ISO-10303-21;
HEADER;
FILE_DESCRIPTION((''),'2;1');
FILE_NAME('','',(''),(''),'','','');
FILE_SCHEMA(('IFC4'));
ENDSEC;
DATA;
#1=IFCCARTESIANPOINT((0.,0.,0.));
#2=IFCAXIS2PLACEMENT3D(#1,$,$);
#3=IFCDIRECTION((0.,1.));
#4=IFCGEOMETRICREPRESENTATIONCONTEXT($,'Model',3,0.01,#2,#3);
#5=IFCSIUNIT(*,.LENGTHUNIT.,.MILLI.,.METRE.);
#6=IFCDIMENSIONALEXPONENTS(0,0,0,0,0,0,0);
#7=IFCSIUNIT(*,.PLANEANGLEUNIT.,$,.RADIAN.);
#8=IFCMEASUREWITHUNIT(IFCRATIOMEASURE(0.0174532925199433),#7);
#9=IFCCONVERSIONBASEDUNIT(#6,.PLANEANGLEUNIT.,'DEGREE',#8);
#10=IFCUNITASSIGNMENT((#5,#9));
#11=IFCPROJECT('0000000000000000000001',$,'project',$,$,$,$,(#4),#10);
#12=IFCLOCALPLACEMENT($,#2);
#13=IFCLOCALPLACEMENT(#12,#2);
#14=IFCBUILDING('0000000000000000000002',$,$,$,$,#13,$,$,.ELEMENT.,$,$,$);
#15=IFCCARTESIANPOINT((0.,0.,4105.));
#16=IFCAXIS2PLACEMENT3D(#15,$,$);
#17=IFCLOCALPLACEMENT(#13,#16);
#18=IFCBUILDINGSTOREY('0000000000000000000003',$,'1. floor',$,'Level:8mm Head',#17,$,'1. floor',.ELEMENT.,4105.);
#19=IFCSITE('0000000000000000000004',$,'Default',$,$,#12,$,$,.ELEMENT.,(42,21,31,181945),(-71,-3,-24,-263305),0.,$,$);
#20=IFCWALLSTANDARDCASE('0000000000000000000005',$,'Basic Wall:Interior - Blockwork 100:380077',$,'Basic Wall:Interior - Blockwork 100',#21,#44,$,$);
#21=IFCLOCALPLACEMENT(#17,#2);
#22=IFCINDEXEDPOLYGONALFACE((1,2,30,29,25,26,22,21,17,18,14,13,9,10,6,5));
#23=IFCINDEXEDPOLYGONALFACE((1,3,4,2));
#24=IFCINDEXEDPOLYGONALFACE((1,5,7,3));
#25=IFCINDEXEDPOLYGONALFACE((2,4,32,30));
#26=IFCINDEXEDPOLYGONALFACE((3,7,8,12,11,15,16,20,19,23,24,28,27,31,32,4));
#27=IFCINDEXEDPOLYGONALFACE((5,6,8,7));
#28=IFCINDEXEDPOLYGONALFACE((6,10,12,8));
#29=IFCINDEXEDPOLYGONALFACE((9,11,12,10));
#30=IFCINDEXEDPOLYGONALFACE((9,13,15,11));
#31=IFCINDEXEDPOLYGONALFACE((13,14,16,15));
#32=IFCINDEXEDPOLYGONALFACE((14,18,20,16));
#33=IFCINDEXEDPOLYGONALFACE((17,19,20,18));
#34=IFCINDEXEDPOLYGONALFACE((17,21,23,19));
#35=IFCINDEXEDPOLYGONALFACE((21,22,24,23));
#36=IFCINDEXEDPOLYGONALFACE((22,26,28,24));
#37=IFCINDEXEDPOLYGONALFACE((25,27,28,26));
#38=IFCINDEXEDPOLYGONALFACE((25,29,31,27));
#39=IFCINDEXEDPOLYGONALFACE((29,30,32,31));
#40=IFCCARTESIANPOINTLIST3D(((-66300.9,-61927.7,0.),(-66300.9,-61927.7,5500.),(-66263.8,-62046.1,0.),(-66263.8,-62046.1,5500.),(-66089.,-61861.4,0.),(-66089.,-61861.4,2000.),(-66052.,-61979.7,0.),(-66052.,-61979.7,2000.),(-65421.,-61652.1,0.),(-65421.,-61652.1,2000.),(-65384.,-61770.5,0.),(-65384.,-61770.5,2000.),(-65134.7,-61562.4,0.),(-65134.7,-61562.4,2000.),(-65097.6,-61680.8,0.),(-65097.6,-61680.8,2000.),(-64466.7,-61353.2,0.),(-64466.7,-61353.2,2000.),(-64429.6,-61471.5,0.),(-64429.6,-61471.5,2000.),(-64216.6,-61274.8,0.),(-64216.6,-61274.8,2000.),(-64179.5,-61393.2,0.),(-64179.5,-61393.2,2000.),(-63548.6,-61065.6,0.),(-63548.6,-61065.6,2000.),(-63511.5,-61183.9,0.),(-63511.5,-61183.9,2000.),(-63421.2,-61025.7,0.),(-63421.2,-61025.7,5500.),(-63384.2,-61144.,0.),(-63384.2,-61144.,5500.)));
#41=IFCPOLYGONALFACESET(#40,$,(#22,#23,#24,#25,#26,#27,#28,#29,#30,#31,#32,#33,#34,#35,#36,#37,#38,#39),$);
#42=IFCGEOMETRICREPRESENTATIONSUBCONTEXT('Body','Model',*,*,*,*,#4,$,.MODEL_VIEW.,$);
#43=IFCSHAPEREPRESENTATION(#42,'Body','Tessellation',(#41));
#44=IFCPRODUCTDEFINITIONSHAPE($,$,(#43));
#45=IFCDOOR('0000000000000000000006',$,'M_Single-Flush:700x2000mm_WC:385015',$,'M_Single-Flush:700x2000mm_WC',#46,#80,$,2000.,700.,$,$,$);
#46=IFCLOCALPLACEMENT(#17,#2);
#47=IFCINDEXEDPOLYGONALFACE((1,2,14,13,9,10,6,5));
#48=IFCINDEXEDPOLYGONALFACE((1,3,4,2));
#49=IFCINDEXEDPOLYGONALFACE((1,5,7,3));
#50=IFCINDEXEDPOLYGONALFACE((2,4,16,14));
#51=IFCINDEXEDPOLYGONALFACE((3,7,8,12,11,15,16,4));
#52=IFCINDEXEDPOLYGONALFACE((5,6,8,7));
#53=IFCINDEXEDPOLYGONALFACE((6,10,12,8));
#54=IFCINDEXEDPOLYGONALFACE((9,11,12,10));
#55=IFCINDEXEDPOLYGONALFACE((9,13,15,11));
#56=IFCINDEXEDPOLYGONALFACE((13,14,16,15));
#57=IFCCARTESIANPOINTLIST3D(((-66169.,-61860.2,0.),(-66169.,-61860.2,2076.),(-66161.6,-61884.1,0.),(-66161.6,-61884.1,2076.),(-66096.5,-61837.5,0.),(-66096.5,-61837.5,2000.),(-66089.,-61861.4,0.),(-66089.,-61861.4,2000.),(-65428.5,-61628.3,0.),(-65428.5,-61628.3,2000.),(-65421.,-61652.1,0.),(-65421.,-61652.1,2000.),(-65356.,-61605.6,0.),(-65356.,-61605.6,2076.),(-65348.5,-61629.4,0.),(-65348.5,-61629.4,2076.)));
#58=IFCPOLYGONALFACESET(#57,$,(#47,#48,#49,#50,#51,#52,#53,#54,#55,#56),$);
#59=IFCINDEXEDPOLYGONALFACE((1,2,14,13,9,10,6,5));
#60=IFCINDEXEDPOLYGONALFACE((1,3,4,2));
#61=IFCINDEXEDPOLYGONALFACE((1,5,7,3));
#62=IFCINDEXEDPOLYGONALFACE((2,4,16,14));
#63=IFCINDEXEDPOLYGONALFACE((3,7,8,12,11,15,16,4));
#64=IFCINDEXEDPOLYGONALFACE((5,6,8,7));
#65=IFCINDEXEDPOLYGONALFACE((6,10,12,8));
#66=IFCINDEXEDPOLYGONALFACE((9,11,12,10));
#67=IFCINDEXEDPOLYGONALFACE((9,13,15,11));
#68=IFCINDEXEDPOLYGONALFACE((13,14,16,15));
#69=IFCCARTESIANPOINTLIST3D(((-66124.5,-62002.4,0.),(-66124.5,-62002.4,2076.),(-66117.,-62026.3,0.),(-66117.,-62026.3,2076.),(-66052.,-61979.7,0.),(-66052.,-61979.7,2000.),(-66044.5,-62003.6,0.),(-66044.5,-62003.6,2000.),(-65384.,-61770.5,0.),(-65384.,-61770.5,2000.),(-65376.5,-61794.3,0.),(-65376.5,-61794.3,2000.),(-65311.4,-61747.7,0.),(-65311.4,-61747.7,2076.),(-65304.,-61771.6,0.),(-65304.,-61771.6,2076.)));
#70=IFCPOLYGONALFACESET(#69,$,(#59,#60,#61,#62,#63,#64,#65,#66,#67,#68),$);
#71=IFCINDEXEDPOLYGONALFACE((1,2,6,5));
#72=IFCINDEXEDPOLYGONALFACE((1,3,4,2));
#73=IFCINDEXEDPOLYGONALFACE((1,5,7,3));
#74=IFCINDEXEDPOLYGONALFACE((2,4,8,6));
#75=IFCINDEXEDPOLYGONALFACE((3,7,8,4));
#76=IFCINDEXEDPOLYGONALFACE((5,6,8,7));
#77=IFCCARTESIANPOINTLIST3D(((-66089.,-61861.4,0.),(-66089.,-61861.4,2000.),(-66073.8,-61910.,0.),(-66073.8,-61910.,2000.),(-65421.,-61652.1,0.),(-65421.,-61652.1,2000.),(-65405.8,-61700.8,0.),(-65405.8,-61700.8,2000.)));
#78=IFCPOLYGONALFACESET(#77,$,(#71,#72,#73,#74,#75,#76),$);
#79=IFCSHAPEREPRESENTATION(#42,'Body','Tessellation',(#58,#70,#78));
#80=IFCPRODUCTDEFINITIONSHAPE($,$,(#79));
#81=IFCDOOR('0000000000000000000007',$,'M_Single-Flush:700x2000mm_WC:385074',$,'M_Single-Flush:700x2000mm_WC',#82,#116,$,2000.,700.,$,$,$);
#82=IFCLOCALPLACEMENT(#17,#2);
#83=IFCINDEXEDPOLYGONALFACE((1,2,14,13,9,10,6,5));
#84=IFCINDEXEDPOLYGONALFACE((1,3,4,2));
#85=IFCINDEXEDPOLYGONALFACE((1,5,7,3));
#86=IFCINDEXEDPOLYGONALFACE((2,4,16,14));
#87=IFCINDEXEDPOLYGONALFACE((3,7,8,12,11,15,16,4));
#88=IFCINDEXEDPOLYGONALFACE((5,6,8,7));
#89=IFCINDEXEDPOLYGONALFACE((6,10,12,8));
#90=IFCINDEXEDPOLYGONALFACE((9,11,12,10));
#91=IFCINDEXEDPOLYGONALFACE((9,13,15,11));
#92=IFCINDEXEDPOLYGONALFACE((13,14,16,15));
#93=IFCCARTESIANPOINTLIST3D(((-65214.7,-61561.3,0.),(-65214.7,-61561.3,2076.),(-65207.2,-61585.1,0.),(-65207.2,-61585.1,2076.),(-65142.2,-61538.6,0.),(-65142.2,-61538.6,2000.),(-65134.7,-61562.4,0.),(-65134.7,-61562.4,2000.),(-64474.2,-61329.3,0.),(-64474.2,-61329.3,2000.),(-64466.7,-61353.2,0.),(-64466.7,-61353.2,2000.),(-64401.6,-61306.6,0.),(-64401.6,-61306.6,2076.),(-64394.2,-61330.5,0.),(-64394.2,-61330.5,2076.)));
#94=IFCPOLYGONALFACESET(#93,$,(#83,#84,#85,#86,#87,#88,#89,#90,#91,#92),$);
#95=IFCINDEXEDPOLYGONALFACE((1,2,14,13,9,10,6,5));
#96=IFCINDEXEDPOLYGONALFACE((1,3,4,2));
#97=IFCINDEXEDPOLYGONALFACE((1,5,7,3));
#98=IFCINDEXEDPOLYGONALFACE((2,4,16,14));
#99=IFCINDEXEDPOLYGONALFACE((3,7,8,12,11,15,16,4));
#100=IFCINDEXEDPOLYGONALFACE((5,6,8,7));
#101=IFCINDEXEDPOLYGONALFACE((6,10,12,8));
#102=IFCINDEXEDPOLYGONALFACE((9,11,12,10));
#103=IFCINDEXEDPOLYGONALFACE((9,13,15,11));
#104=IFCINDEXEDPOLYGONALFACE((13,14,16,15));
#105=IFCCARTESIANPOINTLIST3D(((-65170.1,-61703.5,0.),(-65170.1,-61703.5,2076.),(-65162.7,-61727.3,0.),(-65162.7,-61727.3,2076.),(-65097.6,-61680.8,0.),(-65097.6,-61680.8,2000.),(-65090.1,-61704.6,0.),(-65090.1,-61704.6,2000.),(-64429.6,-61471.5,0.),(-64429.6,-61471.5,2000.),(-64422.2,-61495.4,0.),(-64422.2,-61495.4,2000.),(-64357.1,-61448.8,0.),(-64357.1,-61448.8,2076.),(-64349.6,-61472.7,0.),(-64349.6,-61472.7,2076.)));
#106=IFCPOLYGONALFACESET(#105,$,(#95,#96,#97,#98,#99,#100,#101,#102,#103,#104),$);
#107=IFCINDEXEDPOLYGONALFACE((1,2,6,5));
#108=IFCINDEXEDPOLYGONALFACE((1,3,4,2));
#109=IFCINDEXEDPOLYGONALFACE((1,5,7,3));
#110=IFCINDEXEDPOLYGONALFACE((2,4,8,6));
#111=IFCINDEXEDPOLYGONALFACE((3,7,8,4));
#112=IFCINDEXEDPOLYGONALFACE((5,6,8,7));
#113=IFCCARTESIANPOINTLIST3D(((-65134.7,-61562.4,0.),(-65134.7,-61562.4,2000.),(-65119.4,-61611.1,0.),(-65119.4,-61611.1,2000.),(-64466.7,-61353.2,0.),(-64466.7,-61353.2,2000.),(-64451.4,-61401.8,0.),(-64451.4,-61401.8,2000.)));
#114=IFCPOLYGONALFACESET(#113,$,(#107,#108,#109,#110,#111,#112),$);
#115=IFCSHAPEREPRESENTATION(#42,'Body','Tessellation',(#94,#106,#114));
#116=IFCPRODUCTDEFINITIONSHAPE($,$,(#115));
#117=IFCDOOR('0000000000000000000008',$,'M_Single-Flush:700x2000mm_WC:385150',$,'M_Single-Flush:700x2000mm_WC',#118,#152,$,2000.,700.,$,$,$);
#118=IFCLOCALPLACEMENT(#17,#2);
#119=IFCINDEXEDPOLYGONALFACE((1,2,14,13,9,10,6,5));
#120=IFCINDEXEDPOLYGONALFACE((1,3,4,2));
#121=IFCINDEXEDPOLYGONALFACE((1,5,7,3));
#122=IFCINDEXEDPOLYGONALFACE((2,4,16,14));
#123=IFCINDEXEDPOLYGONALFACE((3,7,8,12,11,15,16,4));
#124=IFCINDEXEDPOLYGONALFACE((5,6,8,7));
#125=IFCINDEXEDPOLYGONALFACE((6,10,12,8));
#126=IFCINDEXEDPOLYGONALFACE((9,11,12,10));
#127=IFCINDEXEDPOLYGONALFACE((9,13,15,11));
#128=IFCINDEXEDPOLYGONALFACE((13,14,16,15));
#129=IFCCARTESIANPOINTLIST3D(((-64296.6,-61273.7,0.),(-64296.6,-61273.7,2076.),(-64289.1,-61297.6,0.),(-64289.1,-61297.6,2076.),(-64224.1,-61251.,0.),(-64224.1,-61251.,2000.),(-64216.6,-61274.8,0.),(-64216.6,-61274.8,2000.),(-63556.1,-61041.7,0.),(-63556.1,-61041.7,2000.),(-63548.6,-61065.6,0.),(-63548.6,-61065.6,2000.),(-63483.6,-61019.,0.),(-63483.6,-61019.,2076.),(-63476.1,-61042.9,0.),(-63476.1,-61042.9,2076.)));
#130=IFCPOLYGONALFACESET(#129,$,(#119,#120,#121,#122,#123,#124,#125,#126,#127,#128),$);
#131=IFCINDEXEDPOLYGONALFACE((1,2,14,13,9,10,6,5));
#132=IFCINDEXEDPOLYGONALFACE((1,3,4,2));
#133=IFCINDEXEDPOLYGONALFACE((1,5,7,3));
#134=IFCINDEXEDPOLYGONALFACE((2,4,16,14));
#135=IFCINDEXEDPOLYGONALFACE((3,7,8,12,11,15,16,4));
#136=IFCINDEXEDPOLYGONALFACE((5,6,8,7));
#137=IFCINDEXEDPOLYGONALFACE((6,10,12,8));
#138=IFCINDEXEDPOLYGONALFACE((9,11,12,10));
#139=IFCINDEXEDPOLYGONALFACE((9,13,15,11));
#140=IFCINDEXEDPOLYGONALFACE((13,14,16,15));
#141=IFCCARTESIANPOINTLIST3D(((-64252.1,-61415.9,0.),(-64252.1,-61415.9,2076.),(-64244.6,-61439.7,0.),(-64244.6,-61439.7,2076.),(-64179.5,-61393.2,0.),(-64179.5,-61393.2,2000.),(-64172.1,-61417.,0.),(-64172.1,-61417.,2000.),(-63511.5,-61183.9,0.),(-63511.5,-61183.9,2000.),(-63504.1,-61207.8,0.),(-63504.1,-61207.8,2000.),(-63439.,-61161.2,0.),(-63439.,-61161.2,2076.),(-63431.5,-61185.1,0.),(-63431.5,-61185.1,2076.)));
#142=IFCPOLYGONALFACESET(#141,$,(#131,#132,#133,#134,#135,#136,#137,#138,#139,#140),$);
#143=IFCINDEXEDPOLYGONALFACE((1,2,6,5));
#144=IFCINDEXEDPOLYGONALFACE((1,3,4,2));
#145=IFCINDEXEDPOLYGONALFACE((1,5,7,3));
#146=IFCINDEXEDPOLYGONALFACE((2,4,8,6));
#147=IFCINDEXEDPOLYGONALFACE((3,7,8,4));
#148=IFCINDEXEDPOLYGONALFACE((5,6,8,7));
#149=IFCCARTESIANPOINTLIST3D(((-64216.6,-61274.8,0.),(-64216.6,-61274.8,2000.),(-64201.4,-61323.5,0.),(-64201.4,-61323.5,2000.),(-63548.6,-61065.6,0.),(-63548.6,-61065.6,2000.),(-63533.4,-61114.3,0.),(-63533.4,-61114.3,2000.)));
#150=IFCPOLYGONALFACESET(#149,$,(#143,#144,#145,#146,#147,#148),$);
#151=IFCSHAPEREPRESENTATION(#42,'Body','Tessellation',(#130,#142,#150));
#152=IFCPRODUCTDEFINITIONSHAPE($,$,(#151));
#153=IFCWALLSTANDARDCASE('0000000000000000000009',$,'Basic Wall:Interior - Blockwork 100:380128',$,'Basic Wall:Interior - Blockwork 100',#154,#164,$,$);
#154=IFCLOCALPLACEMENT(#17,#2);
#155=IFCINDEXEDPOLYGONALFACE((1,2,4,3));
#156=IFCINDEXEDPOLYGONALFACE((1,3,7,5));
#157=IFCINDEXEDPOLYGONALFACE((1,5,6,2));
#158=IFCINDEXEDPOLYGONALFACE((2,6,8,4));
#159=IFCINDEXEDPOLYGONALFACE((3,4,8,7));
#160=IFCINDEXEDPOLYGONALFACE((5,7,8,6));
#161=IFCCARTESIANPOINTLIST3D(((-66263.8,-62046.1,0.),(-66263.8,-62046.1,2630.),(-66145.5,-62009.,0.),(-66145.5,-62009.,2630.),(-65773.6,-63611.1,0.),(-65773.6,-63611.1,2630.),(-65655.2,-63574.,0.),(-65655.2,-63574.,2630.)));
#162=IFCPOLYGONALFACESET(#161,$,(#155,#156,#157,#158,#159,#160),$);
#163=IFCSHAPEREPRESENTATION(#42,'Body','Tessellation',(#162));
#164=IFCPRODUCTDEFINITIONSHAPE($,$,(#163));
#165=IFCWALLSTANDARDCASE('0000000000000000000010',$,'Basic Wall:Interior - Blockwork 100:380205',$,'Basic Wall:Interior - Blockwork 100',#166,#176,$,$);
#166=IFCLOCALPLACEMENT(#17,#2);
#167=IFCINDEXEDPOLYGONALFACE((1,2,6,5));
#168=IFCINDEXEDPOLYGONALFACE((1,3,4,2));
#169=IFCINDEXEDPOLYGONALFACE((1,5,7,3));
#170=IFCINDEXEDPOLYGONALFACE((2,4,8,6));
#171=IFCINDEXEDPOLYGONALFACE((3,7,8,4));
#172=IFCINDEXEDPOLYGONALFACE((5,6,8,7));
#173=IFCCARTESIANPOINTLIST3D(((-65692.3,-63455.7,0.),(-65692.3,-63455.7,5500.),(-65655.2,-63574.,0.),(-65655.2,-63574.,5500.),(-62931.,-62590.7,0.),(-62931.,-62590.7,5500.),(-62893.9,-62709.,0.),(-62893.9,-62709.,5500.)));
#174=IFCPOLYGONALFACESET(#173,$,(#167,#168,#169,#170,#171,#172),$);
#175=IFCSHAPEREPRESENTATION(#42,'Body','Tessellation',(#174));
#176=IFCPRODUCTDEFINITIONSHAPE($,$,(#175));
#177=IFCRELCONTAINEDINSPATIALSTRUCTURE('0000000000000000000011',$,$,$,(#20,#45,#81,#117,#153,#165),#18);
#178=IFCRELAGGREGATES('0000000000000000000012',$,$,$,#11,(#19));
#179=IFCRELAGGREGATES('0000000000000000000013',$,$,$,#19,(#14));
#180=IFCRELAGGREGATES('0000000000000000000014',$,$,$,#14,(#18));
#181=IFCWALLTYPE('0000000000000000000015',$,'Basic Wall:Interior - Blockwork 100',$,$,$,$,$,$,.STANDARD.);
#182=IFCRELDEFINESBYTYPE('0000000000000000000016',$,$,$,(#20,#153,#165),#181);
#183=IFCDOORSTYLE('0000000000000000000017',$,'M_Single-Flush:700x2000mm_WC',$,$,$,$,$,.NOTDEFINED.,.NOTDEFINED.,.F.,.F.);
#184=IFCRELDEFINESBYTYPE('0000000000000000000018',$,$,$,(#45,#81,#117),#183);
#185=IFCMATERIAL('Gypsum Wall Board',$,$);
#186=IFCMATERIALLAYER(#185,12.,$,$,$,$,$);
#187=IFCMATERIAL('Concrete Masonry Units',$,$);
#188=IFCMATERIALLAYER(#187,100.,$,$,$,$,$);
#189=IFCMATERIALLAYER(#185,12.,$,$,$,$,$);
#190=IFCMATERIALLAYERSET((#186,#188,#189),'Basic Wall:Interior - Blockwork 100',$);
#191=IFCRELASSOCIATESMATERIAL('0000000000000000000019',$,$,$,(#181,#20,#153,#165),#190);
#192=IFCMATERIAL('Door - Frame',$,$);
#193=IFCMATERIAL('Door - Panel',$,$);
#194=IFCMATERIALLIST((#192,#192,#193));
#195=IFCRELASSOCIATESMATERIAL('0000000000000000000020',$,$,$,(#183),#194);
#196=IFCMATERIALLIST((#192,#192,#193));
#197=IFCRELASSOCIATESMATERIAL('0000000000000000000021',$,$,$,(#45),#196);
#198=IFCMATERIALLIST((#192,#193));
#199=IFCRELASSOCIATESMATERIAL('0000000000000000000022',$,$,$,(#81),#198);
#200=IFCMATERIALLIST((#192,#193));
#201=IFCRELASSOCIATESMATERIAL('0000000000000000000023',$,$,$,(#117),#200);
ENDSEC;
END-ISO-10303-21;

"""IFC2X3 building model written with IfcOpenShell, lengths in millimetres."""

from ifc_helpers import new_model, entity, si_unit, converted_unit, direction, frame, frame_2d, origin, origin_2d_with_axis, place, context, subcontext, project, spatial, polyline, rectangle, outline, extrude, source, transform, mapped, material, material_list, layer, layer_set, layer_usage, type_object, type_shapes, element, fill, save


model = new_model("IFC2X3")

# Units and contexts
model_context = context("Model", 3, precision=0.01, world=origin(), true_north=direction((0.0, 1.0)))
body_context = subcontext(model_context, "Body", "Model", "MODEL_VIEW")
ifc_project = project(units=[si_unit("LENGTHUNIT", "METRE", prefix="MILLI"), converted_unit("PLANEANGLEUNIT", "DEGREE", entity("IfcRatioMeasure", 0.0174532925199433), si_unit("PLANEANGLEUNIT", "RADIAN"), dimensions=[0, 0, 0, 0, 0, 0, 0])], contexts=[model_context])

# Site, building, storey
site_placement = place(None, origin())
site = spatial("IfcSite", under=ifc_project, at=site_placement, Name="Default", CompositionType="ELEMENT", RefLatitude=(42, 21, 31, 181945), RefLongitude=(-71, -3, -24, -263305), RefElevation=0.0)
building_placement = place(site_placement, origin())
building = spatial("IfcBuilding", under=site, at=building_placement, CompositionType="ELEMENT")
storey_placement = place(building_placement, frame((0.0, 0.0, 4105.0)))
storey = spatial("IfcBuildingStorey", under=building, at=storey_placement, Name="1. floor", ObjectType="Level:8mm Head", LongName="1. floor", CompositionType="ELEMENT", Elevation=4105.0)

# Shared definitions
ifc_material_1 = material(Name="Gypsum Wall Board")
ifc_layer_1 = layer(ifc_material_1, 12.0)
ifc_material_2 = material(Name="Concrete Masonry Units")
ifc_layer_2 = layer(ifc_material_2, 100.0)
ifc_layer_3 = layer(ifc_material_1, 12.0)
ifc_layer_set_1 = layer_set([ifc_layer_1, ifc_layer_2, ifc_layer_3], Name="Basic Wall:Interior - Blockwork 100")
wall_type_1 = type_object("IfcWallType", Name="Basic Wall:Interior - Blockwork 100", PredefinedType="STANDARD", material=ifc_layer_set_1)
ifc_material_3 = material(Name="Door - Frame")
ifc_material_4 = material(Name="Door - Panel")

# Wall, openings, doors
ifc_layer_usage_1 = layer_usage(ifc_layer_set_1, "AXIS2", "NEGATIVE", 62.0)
wall_1_placement = place(storey_placement, frame((-63402.7, -61084.9, 0.0), z_axis=(0.0, 0.0, 1.0), x_axis=(-0.954277, -0.298924, 0.0)))
wall_1 = element("IfcWallStandardCase", 1, at=wall_1_placement, inside=storey, type_object=wall_type_1, material=ifc_layer_usage_1, Name="Basic Wall:Interior - Blockwork 100:380077", ObjectType="Basic Wall:Interior - Blockwork 100", context=body_context, shape_type="SweptSolid", body=[
    extrude(rectangle(XDim=3017.6, YDim=124.0, at=frame_2d((1508.8, 0.0), x_axis=(-1.0, 0.0))), origin(), (0.0, 0.0, 1.0), 5500.0),
])
opening_1_placement = place(wall_1_placement, frame((2795.6, 62.0, 0.0)))
opening_1 = element("IfcOpeningElement", 2, at=opening_1_placement, cuts=wall_1, ObjectType="Opening", context=body_context, shape_type="SweptSolid", body=[
    extrude(rectangle(XDim=700.0, YDim=2000.0, at=frame_2d((1000.0, 350.0), x_axis=(0.0, 1.0))), frame((0.0, 0.0, 0.0), z_axis=(0.0, -1.0, 0.0), x_axis=(0.0, 0.0, 1.0)), (0.0, 0.0, 1.0), 124.0),
])
opening_2_placement = place(wall_1_placement, frame((1795.5, 62.0, 0.0)))
opening_2 = element("IfcOpeningElement", 3, at=opening_2_placement, cuts=wall_1, ObjectType="Opening", context=body_context, shape_type="SweptSolid", body=[
    extrude(rectangle(XDim=700.0, YDim=2000.0, at=frame_2d((1000.0, 350.0), x_axis=(0.0, 1.0))), frame((0.0, 0.0, 0.0), z_axis=(0.0, -1.0, 0.0), x_axis=(0.0, 0.0, 1.0)), (0.0, 0.0, 1.0), 124.0),
])
opening_3_placement = place(wall_1_placement, frame((833.5, 62.0, 0.0)))
opening_3 = element("IfcOpeningElement", 4, at=opening_3_placement, cuts=wall_1, ObjectType="Opening", context=body_context, shape_type="SweptSolid", body=[
    extrude(rectangle(XDim=700.0, YDim=2000.0, at=frame_2d((1000.0, 350.0), x_axis=(0.0, 1.0))), frame((0.0, 0.0, 0.0), z_axis=(0.0, -1.0, 0.0), x_axis=(0.0, 0.0, 1.0)), (0.0, 0.0, 1.0), 124.0),
])
ifc_material_list_1 = material_list([ifc_material_3, ifc_material_3, ifc_material_4])
ifc_material_list_2 = material_list([ifc_material_3, ifc_material_3, ifc_material_4])
door_style_1 = type_object("IfcDoorStyle", Name="M_Single-Flush:700x2000mm_WC", ConstructionType="NOTDEFINED", OperationType="NOTDEFINED", ParameterTakesPrecedence=False, Sizeable=False, material=ifc_material_list_2)
shared_shape_1 = source(origin(), body_context, "Body", "SweptSolid", [
    extrude(outline(polyline([(-426.0, -1057.0), (426.0, -1057.0), (426.0, 1019.0), (350.0, 1019.0), (350.0, -981.0), (-350.0, -981.0), (-350.0, 1019.0), (-426.0, 1019.0), (-426.0, -1057.0)])), frame((350.0, 124.0, 1019.0), z_axis=(0.0, 1.0, 0.0), x_axis=(1.0, 0.0, 0.0)), (0.0, 0.0, 1.0), 25.0),
    extrude(outline(polyline([(-1057.0, -426.0), (1019.0, -426.0), (1019.0, -350.0), (-981.0, -350.0), (-981.0, 350.0), (1019.0, 350.0), (1019.0, 426.0), (-1057.0, 426.0), (-1057.0, -426.0)])), frame((350.0, -25.0, 1019.0), z_axis=(0.0, 1.0, 0.0), x_axis=(0.0, 0.0, -1.0)), (0.0, 0.0, 1.0), 25.0),
    extrude(rectangle(XDim=51.0, YDim=700.0, at=origin_2d_with_axis()), frame((350.0, 98.5, 0.0), z_axis=(0.0, 0.0, 1.0), x_axis=(0.0, 1.0, 0.0)), (0.0, 0.0, 1.0), 2000.0),
])
type_shapes(door_style_1, [shared_shape_1])
door_1_placement = place(opening_1_placement, frame((0.0, 0.0, 0.0), z_axis=(0.0, 0.0, 1.0), x_axis=(-1.0, 0.0, 0.0)))
door_1 = element("IfcDoor", 5, at=door_1_placement, inside=storey, type_object=door_style_1, material=ifc_material_list_1, Name="M_Single-Flush:700x2000mm_WC:385015", ObjectType="M_Single-Flush:700x2000mm_WC", OverallHeight=2000.0, OverallWidth=700.0, context=body_context, shape_type="MappedRepresentation", body=[
    mapped(shared_shape_1, transform((0.0, 0.0, 0.0), scale=1.0)),
])
fill(opening_1, door_1)
ifc_material_list_3 = material_list([ifc_material_3, ifc_material_4])
door_2_placement = place(opening_2_placement, frame((0.0, 0.0, 0.0), z_axis=(0.0, 0.0, 1.0), x_axis=(-1.0, 0.0, 0.0)))
door_2 = element("IfcDoor", 6, at=door_2_placement, inside=storey, type_object=door_style_1, material=ifc_material_list_3, Name="M_Single-Flush:700x2000mm_WC:385074", ObjectType="M_Single-Flush:700x2000mm_WC", OverallHeight=2000.0, OverallWidth=700.0, context=body_context, shape_type="MappedRepresentation", body=[
    mapped(shared_shape_1, transform((0.0, 0.0, 0.0), scale=1.0)),
])
fill(opening_2, door_2)
ifc_material_list_4 = material_list([ifc_material_3, ifc_material_4])
door_3_placement = place(opening_3_placement, frame((0.0, 0.0, 0.0), z_axis=(0.0, 0.0, 1.0), x_axis=(-1.0, 0.0, 0.0)))
door_3 = element("IfcDoor", 7, at=door_3_placement, inside=storey, type_object=door_style_1, material=ifc_material_list_4, Name="M_Single-Flush:700x2000mm_WC:385150", ObjectType="M_Single-Flush:700x2000mm_WC", OverallHeight=2000.0, OverallWidth=700.0, context=body_context, shape_type="MappedRepresentation", body=[
    mapped(shared_shape_1, transform((0.0, 0.0, 0.0), scale=1.0)),
])
fill(opening_3, door_3)

# Walls
ifc_layer_usage_2 = layer_usage(ifc_layer_set_1, "AXIS2", "NEGATIVE", 62.0)
wall_2_placement = place(storey_placement, frame((-66204.6, -62027.5, 0.0), z_axis=(0.0, 0.0, 1.0), x_axis=(0.298924, -0.954277, 0.0)))
element("IfcWallStandardCase", 8, at=wall_2_placement, inside=storey, type_object=wall_type_1, material=ifc_layer_usage_2, Name="Basic Wall:Interior - Blockwork 100:380128", ObjectType="Basic Wall:Interior - Blockwork 100", context=body_context, shape_type="SweptSolid", body=[
    extrude(rectangle(XDim=1640.0, YDim=124.0, at=frame_2d((820.0, 0.0), x_axis=(-1.0, 0.0))), origin(), (0.0, 0.0, 1.0), 2630.0),
])
ifc_layer_usage_3 = layer_usage(ifc_layer_set_1, "AXIS2", "NEGATIVE", 62.0)
wall_3_placement = place(storey_placement, frame((-62912.5, -62649.9, 0.0), z_axis=(0.0, 0.0, 1.0), x_axis=(-0.954277, -0.298924, 0.0)))
element("IfcWallStandardCase", 9, at=wall_3_placement, inside=storey, type_object=wall_type_1, material=ifc_layer_usage_3, Name="Basic Wall:Interior - Blockwork 100:380205", ObjectType="Basic Wall:Interior - Blockwork 100", context=body_context, shape_type="SweptSolid", body=[
    extrude(rectangle(XDim=2893.6, YDim=124.0, at=frame_2d((1446.8, 0.0), x_axis=(-1.0, 0.0))), origin(), (0.0, 0.0, 1.0), 5500.0),
])

save(model, "model.ifc")
